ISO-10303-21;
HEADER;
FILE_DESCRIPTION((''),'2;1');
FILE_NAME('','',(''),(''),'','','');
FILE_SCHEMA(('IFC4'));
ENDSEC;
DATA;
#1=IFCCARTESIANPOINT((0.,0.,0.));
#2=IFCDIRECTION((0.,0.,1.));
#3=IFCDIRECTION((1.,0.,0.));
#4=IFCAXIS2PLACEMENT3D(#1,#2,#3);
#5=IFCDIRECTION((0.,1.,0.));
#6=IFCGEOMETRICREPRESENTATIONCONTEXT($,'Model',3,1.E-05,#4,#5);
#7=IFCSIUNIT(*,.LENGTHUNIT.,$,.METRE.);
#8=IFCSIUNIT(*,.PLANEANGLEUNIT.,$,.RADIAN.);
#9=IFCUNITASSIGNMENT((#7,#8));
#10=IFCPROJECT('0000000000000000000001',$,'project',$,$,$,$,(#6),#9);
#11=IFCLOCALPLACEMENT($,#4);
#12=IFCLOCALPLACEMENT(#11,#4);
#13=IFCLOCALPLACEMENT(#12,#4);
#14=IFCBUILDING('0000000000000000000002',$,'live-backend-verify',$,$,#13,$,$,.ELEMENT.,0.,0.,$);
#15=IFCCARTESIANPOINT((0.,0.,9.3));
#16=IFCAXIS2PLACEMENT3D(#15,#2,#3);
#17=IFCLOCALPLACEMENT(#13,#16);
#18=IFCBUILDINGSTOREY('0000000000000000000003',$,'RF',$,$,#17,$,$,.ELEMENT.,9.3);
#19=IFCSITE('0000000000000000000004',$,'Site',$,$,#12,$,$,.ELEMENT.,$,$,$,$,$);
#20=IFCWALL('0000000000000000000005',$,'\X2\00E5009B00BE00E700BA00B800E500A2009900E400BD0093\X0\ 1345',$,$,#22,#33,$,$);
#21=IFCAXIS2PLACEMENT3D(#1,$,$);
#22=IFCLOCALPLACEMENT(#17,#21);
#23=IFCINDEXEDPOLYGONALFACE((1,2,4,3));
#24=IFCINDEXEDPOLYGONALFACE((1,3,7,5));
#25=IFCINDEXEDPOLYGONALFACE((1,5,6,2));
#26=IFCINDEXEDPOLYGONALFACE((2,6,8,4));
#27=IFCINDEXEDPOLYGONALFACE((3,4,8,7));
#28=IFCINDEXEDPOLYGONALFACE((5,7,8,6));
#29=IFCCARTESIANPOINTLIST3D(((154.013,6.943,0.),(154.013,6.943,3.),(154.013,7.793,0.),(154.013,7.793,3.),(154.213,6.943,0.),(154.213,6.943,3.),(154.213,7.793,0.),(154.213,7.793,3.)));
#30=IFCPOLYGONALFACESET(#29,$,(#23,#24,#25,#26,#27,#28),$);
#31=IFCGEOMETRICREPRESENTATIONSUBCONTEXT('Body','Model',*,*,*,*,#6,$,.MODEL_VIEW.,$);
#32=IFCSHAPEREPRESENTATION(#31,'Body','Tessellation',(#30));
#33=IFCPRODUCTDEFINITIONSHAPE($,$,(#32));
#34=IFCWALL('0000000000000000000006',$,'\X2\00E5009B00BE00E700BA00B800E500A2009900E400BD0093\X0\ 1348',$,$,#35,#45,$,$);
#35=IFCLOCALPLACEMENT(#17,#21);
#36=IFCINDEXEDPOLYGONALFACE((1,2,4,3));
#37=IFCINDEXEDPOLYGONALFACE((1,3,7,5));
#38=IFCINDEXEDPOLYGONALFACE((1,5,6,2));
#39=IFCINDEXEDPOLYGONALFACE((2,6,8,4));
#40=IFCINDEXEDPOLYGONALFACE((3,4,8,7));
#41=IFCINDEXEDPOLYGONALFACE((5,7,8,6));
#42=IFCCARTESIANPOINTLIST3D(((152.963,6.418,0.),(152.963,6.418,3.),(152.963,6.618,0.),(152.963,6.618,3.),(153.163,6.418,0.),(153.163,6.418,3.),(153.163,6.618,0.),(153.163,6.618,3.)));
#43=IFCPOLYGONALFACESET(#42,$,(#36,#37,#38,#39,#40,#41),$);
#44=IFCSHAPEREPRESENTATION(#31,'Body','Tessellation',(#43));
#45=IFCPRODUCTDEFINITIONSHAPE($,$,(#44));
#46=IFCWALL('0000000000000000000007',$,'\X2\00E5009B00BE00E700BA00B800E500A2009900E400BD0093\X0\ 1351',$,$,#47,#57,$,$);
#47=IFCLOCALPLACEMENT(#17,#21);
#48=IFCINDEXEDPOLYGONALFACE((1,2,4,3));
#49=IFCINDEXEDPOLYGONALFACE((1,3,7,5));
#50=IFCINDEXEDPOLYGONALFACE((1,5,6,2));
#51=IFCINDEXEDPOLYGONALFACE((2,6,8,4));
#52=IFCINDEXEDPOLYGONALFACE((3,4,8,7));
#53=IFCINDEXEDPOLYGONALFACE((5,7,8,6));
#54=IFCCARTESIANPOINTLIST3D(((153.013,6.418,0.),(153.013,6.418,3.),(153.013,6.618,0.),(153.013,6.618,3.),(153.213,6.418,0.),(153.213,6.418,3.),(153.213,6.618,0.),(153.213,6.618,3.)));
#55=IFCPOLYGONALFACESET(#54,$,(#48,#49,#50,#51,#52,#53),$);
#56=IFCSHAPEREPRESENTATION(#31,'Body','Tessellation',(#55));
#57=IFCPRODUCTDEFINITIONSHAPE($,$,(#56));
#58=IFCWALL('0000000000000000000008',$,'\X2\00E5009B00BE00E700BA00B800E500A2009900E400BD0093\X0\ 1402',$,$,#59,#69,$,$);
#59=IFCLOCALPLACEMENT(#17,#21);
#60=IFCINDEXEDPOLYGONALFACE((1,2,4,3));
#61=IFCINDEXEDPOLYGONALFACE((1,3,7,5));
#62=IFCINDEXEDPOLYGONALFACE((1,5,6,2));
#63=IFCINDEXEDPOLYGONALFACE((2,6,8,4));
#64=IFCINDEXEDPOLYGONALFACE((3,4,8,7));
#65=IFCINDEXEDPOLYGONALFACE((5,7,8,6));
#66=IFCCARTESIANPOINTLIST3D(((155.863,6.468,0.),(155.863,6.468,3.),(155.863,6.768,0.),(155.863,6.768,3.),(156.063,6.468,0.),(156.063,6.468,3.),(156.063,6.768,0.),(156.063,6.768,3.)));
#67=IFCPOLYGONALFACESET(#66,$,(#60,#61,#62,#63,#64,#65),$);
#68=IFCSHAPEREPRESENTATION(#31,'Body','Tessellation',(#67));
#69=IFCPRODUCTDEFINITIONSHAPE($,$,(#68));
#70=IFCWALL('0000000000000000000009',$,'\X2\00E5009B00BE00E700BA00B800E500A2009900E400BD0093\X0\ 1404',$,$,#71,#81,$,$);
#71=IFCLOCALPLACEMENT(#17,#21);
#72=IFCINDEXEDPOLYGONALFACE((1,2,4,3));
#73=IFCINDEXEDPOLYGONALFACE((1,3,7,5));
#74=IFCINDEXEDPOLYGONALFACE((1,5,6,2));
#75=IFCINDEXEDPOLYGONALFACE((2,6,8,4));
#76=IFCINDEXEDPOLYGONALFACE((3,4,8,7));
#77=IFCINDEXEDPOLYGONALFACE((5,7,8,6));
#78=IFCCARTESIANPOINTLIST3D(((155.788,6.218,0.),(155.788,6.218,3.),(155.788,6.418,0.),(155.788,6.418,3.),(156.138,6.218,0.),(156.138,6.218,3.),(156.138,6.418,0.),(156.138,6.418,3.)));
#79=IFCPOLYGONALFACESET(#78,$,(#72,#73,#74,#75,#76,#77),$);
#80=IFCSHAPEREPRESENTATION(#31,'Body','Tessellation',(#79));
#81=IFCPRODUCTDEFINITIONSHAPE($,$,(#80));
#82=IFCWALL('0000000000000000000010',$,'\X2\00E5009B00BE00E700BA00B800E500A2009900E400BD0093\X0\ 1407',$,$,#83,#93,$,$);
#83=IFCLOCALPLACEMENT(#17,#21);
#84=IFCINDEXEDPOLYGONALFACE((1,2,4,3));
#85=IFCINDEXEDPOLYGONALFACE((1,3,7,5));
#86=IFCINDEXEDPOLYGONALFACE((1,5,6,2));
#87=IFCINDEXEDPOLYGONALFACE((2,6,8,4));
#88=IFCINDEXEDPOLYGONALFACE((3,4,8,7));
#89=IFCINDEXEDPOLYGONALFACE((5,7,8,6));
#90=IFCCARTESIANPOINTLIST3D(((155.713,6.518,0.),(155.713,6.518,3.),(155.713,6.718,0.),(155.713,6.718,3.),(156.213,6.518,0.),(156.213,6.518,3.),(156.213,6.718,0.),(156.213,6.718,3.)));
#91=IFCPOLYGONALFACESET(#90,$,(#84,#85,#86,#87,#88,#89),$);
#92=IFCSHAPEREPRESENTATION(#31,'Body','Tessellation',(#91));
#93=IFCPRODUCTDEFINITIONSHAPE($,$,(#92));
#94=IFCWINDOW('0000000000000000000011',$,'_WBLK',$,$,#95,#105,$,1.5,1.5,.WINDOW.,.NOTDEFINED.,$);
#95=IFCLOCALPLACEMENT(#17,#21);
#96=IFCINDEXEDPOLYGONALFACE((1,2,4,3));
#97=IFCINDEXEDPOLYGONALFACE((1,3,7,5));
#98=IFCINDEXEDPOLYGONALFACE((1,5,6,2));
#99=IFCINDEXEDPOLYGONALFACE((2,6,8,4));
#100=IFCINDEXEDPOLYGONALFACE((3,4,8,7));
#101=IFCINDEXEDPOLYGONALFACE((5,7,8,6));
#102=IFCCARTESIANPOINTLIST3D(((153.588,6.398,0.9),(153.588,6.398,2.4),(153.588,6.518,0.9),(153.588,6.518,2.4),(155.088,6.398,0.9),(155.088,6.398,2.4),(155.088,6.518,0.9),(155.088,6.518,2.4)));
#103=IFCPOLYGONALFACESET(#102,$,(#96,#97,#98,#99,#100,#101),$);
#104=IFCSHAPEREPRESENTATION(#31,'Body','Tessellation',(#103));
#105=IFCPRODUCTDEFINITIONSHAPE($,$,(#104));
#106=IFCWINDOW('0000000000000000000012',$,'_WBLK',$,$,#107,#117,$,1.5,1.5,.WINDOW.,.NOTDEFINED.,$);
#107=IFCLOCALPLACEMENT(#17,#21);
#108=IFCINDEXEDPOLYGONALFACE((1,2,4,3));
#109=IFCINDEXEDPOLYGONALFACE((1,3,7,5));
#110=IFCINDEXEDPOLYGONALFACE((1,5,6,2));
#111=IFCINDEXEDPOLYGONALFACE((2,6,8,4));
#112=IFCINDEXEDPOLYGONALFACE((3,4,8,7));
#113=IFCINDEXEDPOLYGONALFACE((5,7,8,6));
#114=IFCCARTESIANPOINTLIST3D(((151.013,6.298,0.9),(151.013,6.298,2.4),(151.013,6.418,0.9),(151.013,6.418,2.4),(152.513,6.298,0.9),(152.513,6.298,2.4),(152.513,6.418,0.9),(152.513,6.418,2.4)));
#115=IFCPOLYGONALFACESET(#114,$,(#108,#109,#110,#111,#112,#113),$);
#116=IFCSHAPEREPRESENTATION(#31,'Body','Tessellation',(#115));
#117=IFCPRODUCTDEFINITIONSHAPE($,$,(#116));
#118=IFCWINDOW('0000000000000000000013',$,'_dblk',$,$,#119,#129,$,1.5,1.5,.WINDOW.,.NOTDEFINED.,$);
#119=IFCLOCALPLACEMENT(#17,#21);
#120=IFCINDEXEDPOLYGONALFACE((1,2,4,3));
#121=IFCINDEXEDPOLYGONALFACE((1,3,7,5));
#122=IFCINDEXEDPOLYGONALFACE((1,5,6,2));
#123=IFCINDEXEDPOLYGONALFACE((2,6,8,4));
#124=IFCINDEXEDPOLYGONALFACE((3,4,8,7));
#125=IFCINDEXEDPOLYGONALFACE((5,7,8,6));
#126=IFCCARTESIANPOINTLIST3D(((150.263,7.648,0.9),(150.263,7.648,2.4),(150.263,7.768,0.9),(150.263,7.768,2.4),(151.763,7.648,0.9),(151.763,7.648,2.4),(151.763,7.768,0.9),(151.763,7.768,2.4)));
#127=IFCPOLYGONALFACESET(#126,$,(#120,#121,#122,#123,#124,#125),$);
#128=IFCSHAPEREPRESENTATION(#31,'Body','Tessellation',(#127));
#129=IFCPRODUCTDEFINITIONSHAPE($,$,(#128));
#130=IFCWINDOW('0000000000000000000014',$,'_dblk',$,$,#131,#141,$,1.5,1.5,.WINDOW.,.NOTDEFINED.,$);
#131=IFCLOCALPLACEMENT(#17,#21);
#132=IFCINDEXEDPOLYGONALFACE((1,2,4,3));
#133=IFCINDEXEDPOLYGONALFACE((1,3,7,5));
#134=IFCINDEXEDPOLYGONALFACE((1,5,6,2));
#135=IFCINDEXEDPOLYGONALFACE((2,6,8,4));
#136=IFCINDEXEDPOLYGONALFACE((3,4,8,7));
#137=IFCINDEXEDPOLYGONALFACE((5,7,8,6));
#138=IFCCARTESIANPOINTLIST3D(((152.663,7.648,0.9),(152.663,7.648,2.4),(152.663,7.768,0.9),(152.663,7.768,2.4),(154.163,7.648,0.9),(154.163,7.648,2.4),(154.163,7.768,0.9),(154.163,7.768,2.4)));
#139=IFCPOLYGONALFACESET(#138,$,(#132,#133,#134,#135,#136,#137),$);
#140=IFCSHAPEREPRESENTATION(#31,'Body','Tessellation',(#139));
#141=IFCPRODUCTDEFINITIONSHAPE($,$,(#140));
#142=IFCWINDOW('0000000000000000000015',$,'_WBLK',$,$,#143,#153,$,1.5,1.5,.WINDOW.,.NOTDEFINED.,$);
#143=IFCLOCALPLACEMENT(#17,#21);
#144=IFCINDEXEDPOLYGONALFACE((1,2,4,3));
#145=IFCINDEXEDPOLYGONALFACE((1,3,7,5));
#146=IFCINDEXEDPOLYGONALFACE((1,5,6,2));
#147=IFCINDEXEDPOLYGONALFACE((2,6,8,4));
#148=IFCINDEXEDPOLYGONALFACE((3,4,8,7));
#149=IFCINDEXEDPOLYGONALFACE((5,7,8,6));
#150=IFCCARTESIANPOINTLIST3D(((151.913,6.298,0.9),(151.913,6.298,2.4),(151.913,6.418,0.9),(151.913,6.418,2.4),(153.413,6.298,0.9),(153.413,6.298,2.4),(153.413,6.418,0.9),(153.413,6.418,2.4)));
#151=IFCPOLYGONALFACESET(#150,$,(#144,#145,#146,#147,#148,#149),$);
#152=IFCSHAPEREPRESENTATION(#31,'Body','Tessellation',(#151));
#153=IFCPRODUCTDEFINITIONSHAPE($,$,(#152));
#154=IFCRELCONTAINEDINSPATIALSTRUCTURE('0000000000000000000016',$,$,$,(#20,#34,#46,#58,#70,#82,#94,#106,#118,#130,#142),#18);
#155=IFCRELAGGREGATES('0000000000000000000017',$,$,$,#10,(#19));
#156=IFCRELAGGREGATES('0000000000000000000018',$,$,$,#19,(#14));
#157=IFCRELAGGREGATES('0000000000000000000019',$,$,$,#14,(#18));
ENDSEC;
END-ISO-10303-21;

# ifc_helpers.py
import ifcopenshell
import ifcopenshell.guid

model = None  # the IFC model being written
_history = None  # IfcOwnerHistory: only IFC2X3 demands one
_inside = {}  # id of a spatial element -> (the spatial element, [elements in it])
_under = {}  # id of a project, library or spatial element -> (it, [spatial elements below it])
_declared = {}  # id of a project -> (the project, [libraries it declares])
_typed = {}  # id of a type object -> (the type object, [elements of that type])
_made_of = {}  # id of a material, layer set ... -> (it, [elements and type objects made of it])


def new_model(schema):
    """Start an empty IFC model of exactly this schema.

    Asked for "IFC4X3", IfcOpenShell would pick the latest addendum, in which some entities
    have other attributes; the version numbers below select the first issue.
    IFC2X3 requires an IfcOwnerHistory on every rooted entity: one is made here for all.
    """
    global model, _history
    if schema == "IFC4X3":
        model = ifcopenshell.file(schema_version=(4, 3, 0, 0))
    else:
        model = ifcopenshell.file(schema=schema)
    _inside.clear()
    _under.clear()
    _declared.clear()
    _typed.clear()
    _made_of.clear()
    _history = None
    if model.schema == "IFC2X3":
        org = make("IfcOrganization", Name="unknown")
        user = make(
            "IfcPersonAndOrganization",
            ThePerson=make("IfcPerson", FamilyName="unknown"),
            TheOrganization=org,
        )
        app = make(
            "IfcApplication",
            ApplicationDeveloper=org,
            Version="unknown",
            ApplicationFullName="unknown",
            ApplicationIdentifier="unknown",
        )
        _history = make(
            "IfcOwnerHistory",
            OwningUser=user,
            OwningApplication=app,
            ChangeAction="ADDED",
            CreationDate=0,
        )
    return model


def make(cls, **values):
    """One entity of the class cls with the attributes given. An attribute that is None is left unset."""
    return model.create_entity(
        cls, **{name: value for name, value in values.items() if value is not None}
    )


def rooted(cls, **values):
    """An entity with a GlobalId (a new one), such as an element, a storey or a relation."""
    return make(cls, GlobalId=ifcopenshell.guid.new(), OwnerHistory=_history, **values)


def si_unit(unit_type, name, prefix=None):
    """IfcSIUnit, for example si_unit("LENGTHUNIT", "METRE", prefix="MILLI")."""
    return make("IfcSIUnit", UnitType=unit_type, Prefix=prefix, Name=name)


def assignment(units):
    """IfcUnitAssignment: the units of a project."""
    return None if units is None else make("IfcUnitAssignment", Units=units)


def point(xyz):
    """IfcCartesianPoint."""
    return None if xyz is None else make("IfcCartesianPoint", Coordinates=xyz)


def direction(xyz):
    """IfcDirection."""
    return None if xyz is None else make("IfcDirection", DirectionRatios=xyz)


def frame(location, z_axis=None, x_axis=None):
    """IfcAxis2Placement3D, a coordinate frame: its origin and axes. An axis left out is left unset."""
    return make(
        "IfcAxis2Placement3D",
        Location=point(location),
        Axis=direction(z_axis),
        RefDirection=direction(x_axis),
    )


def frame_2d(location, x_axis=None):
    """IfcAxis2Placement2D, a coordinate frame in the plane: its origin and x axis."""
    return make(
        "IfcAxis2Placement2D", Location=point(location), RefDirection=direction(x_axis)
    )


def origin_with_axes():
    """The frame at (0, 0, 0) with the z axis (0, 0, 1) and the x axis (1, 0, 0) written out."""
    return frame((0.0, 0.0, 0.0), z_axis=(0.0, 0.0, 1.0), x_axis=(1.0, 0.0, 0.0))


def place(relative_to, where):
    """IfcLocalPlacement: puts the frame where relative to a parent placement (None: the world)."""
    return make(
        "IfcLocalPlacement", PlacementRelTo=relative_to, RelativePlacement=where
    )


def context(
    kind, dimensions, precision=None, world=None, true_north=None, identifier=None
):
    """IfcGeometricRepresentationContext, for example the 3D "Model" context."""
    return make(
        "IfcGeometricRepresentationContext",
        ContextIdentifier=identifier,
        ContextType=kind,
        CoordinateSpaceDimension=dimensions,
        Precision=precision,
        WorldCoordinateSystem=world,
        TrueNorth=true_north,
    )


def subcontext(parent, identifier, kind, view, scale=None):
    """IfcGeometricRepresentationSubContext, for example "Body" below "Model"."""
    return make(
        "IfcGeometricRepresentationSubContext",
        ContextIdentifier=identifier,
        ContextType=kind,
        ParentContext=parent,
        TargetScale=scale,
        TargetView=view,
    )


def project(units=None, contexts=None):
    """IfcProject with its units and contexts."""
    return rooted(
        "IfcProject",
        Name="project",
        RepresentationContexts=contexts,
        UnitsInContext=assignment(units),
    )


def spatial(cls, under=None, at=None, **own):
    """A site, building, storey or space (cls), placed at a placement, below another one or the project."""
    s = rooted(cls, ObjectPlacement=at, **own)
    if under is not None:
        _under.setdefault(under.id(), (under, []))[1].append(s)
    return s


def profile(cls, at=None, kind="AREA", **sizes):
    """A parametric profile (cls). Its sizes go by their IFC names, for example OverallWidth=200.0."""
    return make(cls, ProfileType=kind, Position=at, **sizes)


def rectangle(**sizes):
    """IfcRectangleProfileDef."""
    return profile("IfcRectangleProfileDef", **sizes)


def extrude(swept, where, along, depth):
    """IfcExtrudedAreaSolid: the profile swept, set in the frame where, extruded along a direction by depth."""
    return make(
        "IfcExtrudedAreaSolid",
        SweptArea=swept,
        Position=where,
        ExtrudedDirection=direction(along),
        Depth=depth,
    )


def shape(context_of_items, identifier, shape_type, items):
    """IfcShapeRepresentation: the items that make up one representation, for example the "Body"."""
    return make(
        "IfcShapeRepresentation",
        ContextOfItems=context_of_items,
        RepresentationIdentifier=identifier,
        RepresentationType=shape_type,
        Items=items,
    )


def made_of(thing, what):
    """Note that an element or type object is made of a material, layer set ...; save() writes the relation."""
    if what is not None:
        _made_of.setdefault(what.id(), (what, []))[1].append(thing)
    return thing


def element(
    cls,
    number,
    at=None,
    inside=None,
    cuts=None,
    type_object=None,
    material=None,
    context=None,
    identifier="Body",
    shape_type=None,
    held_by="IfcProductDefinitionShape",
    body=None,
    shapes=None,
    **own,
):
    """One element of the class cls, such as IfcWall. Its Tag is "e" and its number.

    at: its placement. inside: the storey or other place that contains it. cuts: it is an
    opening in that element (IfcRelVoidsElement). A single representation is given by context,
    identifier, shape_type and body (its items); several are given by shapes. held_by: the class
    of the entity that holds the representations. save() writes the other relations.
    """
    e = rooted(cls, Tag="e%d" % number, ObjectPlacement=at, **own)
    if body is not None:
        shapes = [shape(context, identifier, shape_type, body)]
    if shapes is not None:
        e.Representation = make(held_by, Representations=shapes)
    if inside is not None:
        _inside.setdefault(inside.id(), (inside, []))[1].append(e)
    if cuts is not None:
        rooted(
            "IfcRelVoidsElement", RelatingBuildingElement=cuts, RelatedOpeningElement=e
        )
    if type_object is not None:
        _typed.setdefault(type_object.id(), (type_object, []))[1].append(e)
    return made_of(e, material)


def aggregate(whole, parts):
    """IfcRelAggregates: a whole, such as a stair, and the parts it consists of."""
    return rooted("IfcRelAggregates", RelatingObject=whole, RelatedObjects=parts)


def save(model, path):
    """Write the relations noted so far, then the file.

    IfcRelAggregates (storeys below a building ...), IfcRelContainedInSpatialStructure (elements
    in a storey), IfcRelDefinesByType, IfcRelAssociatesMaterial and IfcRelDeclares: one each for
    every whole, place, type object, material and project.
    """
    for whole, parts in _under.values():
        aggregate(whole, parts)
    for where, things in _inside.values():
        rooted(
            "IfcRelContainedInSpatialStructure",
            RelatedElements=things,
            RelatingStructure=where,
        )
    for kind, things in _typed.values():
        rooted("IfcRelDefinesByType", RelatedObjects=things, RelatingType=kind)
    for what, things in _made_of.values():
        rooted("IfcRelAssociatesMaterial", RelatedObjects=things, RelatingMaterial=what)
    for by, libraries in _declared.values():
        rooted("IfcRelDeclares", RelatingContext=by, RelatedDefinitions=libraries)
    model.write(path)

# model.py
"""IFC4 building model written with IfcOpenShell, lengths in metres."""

from ifc_helpers import new_model, si_unit, direction, frame, frame_2d, origin_with_axes, place, context, subcontext, project, spatial, rectangle, extrude, element, save


model = new_model("IFC4")

# Units and contexts
model_context = context("Model", 3, precision=1e-05, world=origin_with_axes(), true_north=direction((0.0, 1.0, 0.0)))
body_context = subcontext(model_context, "Body", "Model", "MODEL_VIEW")
ifc_project = project(units=[si_unit("LENGTHUNIT", "METRE"), si_unit("PLANEANGLEUNIT", "RADIAN")], contexts=[model_context])

# Site, building, storey
placement = place(None, origin_with_axes())
site_placement = place(placement, origin_with_axes())
site = spatial("IfcSite", under=ifc_project, at=site_placement, Name="Site", CompositionType="ELEMENT")
building_placement = place(site_placement, origin_with_axes())
building = spatial("IfcBuilding", under=site, at=building_placement, Name="live-backend-verify", CompositionType="ELEMENT", ElevationOfRefHeight=0.0, ElevationOfTerrain=0.0)
storey_placement = place(building_placement, frame((0.0, 0.0, 9.3), z_axis=(0.0, 0.0, 1.0), x_axis=(1.0, 0.0, 0.0)))
storey = spatial("IfcBuildingStorey", under=building, at=storey_placement, Name="RF", CompositionType="ELEMENT", Elevation=9.3)

# Walls
for number, where, z_axis, x_axis, name in (
    (1, (154.113, 7.368, 0.0), (0.0, 0.0, 1.0), (0.0, -1.0, 0.0), "å\u009b¾çº¸å¢\u0099ä½\u0093 1345"),
):
    element("IfcWall", number, at=place(storey_placement, frame(where, z_axis=z_axis, x_axis=x_axis)), inside=storey, Name=name, context=body_context, shape_type="SweptSolid", body=[
        extrude(rectangle(XDim=0.85, YDim=0.2, at=frame_2d((0.0, 0.0), x_axis=(1.0, 0.0, 0.0))), frame((0.0, 0.0, 0.0), z_axis=(0.0, 0.0, 1.0)), (0.0, 0.0, 1.0), 3.0),
    ])
for number, where, z_axis, x_axis, name in (
    (2, (153.063, 6.518, 0.0), (0.0, 0.0, 1.0), (1.0, 0.0, 0.0), "å\u009b¾çº¸å¢\u0099ä½\u0093 1348"),
    (3, (153.113, 6.518, 0.0), (0.0, 0.0, 1.0), (0.0, -1.0, 0.0), "å\u009b¾çº¸å¢\u0099ä½\u0093 1351"),
):
    element("IfcWall", number, at=place(storey_placement, frame(where, z_axis=z_axis, x_axis=x_axis)), inside=storey, Name=name, context=body_context, shape_type="SweptSolid", body=[
        extrude(rectangle(XDim=0.2, YDim=0.2, at=frame_2d((0.0, 0.0), x_axis=(1.0, 0.0, 0.0))), frame((0.0, 0.0, 0.0), z_axis=(0.0, 0.0, 1.0)), (0.0, 0.0, 1.0), 3.0),
    ])
wall_1_placement = place(storey_placement, frame((155.963, 6.618, 0.0), z_axis=(0.0, 0.0, 1.0), x_axis=(0.0, -1.0, 0.0)))
element("IfcWall", 4, at=wall_1_placement, inside=storey, Name="å\u009b¾çº¸å¢\u0099ä½\u0093 1402", context=body_context, shape_type="SweptSolid", body=[
    extrude(rectangle(XDim=0.3, YDim=0.2, at=frame_2d((0.0, 0.0), x_axis=(1.0, 0.0, 0.0))), frame((0.0, 0.0, 0.0), z_axis=(0.0, 0.0, 1.0)), (0.0, 0.0, 1.0), 3.0),
])
wall_2_placement = place(storey_placement, frame((155.963, 6.318, 0.0), z_axis=(0.0, 0.0, 1.0), x_axis=(1.0, 0.0, 0.0)))
element("IfcWall", 5, at=wall_2_placement, inside=storey, Name="å\u009b¾çº¸å¢\u0099ä½\u0093 1404", context=body_context, shape_type="SweptSolid", body=[
    extrude(rectangle(XDim=0.35, YDim=0.2, at=frame_2d((0.0, 0.0), x_axis=(1.0, 0.0, 0.0))), frame((0.0, 0.0, 0.0), z_axis=(0.0, 0.0, 1.0)), (0.0, 0.0, 1.0), 3.0),
])
wall_3_placement = place(storey_placement, frame((155.963, 6.618, 0.0), z_axis=(0.0, 0.0, 1.0), x_axis=(1.0, 0.0, 0.0)))
element("IfcWall", 6, at=wall_3_placement, inside=storey, Name="å\u009b¾çº¸å¢\u0099ä½\u0093 1407", context=body_context, shape_type="SweptSolid", body=[
    extrude(rectangle(XDim=0.5, YDim=0.2, at=frame_2d((0.0, 0.0), x_axis=(1.0, 0.0, 0.0))), frame((0.0, 0.0, 0.0), z_axis=(0.0, 0.0, 1.0)), (0.0, 0.0, 1.0), 3.0),
])

# Windows
for number, where, z_axis, x_axis, name in (
    (7, (154.338, 6.458, 0.9), (0.0, 0.0, 1.0), (1.0, 0.0, 0.0), "_WBLK"),
    (8, (151.763, 6.358, 0.9), (0.0, 0.0, 1.0), (1.0, 0.0, 0.0), "_WBLK"),
    (9, (151.013, 7.708, 0.9), (0.0, 0.0, 1.0), (1.0, 0.0, 0.0), "_dblk"),
    (10, (153.413, 7.708, 0.9), (0.0, 0.0, 1.0), (1.0, 0.0, 0.0), "_dblk"),
    (11, (152.663, 6.358, 0.9), (0.0, 0.0, 1.0), (1.0, 0.0, 0.0), "_WBLK"),
):
    element("IfcWindow", number, at=place(storey_placement, frame(where, z_axis=z_axis, x_axis=x_axis)), inside=storey, Name=name, OverallHeight=1.5, OverallWidth=1.5, PartitioningType="NOTDEFINED", PredefinedType="WINDOW", context=body_context, shape_type="SweptSolid", body=[
        extrude(rectangle(XDim=1.5, YDim=0.12, at=frame_2d((0.0, 0.0), x_axis=(1.0, 0.0, 0.0))), frame((0.0, 0.0, 0.0), z_axis=(0.0, 0.0, 1.0)), (0.0, 0.0, 1.0), 1.5),
    ])

save(model, "model.ifc")
